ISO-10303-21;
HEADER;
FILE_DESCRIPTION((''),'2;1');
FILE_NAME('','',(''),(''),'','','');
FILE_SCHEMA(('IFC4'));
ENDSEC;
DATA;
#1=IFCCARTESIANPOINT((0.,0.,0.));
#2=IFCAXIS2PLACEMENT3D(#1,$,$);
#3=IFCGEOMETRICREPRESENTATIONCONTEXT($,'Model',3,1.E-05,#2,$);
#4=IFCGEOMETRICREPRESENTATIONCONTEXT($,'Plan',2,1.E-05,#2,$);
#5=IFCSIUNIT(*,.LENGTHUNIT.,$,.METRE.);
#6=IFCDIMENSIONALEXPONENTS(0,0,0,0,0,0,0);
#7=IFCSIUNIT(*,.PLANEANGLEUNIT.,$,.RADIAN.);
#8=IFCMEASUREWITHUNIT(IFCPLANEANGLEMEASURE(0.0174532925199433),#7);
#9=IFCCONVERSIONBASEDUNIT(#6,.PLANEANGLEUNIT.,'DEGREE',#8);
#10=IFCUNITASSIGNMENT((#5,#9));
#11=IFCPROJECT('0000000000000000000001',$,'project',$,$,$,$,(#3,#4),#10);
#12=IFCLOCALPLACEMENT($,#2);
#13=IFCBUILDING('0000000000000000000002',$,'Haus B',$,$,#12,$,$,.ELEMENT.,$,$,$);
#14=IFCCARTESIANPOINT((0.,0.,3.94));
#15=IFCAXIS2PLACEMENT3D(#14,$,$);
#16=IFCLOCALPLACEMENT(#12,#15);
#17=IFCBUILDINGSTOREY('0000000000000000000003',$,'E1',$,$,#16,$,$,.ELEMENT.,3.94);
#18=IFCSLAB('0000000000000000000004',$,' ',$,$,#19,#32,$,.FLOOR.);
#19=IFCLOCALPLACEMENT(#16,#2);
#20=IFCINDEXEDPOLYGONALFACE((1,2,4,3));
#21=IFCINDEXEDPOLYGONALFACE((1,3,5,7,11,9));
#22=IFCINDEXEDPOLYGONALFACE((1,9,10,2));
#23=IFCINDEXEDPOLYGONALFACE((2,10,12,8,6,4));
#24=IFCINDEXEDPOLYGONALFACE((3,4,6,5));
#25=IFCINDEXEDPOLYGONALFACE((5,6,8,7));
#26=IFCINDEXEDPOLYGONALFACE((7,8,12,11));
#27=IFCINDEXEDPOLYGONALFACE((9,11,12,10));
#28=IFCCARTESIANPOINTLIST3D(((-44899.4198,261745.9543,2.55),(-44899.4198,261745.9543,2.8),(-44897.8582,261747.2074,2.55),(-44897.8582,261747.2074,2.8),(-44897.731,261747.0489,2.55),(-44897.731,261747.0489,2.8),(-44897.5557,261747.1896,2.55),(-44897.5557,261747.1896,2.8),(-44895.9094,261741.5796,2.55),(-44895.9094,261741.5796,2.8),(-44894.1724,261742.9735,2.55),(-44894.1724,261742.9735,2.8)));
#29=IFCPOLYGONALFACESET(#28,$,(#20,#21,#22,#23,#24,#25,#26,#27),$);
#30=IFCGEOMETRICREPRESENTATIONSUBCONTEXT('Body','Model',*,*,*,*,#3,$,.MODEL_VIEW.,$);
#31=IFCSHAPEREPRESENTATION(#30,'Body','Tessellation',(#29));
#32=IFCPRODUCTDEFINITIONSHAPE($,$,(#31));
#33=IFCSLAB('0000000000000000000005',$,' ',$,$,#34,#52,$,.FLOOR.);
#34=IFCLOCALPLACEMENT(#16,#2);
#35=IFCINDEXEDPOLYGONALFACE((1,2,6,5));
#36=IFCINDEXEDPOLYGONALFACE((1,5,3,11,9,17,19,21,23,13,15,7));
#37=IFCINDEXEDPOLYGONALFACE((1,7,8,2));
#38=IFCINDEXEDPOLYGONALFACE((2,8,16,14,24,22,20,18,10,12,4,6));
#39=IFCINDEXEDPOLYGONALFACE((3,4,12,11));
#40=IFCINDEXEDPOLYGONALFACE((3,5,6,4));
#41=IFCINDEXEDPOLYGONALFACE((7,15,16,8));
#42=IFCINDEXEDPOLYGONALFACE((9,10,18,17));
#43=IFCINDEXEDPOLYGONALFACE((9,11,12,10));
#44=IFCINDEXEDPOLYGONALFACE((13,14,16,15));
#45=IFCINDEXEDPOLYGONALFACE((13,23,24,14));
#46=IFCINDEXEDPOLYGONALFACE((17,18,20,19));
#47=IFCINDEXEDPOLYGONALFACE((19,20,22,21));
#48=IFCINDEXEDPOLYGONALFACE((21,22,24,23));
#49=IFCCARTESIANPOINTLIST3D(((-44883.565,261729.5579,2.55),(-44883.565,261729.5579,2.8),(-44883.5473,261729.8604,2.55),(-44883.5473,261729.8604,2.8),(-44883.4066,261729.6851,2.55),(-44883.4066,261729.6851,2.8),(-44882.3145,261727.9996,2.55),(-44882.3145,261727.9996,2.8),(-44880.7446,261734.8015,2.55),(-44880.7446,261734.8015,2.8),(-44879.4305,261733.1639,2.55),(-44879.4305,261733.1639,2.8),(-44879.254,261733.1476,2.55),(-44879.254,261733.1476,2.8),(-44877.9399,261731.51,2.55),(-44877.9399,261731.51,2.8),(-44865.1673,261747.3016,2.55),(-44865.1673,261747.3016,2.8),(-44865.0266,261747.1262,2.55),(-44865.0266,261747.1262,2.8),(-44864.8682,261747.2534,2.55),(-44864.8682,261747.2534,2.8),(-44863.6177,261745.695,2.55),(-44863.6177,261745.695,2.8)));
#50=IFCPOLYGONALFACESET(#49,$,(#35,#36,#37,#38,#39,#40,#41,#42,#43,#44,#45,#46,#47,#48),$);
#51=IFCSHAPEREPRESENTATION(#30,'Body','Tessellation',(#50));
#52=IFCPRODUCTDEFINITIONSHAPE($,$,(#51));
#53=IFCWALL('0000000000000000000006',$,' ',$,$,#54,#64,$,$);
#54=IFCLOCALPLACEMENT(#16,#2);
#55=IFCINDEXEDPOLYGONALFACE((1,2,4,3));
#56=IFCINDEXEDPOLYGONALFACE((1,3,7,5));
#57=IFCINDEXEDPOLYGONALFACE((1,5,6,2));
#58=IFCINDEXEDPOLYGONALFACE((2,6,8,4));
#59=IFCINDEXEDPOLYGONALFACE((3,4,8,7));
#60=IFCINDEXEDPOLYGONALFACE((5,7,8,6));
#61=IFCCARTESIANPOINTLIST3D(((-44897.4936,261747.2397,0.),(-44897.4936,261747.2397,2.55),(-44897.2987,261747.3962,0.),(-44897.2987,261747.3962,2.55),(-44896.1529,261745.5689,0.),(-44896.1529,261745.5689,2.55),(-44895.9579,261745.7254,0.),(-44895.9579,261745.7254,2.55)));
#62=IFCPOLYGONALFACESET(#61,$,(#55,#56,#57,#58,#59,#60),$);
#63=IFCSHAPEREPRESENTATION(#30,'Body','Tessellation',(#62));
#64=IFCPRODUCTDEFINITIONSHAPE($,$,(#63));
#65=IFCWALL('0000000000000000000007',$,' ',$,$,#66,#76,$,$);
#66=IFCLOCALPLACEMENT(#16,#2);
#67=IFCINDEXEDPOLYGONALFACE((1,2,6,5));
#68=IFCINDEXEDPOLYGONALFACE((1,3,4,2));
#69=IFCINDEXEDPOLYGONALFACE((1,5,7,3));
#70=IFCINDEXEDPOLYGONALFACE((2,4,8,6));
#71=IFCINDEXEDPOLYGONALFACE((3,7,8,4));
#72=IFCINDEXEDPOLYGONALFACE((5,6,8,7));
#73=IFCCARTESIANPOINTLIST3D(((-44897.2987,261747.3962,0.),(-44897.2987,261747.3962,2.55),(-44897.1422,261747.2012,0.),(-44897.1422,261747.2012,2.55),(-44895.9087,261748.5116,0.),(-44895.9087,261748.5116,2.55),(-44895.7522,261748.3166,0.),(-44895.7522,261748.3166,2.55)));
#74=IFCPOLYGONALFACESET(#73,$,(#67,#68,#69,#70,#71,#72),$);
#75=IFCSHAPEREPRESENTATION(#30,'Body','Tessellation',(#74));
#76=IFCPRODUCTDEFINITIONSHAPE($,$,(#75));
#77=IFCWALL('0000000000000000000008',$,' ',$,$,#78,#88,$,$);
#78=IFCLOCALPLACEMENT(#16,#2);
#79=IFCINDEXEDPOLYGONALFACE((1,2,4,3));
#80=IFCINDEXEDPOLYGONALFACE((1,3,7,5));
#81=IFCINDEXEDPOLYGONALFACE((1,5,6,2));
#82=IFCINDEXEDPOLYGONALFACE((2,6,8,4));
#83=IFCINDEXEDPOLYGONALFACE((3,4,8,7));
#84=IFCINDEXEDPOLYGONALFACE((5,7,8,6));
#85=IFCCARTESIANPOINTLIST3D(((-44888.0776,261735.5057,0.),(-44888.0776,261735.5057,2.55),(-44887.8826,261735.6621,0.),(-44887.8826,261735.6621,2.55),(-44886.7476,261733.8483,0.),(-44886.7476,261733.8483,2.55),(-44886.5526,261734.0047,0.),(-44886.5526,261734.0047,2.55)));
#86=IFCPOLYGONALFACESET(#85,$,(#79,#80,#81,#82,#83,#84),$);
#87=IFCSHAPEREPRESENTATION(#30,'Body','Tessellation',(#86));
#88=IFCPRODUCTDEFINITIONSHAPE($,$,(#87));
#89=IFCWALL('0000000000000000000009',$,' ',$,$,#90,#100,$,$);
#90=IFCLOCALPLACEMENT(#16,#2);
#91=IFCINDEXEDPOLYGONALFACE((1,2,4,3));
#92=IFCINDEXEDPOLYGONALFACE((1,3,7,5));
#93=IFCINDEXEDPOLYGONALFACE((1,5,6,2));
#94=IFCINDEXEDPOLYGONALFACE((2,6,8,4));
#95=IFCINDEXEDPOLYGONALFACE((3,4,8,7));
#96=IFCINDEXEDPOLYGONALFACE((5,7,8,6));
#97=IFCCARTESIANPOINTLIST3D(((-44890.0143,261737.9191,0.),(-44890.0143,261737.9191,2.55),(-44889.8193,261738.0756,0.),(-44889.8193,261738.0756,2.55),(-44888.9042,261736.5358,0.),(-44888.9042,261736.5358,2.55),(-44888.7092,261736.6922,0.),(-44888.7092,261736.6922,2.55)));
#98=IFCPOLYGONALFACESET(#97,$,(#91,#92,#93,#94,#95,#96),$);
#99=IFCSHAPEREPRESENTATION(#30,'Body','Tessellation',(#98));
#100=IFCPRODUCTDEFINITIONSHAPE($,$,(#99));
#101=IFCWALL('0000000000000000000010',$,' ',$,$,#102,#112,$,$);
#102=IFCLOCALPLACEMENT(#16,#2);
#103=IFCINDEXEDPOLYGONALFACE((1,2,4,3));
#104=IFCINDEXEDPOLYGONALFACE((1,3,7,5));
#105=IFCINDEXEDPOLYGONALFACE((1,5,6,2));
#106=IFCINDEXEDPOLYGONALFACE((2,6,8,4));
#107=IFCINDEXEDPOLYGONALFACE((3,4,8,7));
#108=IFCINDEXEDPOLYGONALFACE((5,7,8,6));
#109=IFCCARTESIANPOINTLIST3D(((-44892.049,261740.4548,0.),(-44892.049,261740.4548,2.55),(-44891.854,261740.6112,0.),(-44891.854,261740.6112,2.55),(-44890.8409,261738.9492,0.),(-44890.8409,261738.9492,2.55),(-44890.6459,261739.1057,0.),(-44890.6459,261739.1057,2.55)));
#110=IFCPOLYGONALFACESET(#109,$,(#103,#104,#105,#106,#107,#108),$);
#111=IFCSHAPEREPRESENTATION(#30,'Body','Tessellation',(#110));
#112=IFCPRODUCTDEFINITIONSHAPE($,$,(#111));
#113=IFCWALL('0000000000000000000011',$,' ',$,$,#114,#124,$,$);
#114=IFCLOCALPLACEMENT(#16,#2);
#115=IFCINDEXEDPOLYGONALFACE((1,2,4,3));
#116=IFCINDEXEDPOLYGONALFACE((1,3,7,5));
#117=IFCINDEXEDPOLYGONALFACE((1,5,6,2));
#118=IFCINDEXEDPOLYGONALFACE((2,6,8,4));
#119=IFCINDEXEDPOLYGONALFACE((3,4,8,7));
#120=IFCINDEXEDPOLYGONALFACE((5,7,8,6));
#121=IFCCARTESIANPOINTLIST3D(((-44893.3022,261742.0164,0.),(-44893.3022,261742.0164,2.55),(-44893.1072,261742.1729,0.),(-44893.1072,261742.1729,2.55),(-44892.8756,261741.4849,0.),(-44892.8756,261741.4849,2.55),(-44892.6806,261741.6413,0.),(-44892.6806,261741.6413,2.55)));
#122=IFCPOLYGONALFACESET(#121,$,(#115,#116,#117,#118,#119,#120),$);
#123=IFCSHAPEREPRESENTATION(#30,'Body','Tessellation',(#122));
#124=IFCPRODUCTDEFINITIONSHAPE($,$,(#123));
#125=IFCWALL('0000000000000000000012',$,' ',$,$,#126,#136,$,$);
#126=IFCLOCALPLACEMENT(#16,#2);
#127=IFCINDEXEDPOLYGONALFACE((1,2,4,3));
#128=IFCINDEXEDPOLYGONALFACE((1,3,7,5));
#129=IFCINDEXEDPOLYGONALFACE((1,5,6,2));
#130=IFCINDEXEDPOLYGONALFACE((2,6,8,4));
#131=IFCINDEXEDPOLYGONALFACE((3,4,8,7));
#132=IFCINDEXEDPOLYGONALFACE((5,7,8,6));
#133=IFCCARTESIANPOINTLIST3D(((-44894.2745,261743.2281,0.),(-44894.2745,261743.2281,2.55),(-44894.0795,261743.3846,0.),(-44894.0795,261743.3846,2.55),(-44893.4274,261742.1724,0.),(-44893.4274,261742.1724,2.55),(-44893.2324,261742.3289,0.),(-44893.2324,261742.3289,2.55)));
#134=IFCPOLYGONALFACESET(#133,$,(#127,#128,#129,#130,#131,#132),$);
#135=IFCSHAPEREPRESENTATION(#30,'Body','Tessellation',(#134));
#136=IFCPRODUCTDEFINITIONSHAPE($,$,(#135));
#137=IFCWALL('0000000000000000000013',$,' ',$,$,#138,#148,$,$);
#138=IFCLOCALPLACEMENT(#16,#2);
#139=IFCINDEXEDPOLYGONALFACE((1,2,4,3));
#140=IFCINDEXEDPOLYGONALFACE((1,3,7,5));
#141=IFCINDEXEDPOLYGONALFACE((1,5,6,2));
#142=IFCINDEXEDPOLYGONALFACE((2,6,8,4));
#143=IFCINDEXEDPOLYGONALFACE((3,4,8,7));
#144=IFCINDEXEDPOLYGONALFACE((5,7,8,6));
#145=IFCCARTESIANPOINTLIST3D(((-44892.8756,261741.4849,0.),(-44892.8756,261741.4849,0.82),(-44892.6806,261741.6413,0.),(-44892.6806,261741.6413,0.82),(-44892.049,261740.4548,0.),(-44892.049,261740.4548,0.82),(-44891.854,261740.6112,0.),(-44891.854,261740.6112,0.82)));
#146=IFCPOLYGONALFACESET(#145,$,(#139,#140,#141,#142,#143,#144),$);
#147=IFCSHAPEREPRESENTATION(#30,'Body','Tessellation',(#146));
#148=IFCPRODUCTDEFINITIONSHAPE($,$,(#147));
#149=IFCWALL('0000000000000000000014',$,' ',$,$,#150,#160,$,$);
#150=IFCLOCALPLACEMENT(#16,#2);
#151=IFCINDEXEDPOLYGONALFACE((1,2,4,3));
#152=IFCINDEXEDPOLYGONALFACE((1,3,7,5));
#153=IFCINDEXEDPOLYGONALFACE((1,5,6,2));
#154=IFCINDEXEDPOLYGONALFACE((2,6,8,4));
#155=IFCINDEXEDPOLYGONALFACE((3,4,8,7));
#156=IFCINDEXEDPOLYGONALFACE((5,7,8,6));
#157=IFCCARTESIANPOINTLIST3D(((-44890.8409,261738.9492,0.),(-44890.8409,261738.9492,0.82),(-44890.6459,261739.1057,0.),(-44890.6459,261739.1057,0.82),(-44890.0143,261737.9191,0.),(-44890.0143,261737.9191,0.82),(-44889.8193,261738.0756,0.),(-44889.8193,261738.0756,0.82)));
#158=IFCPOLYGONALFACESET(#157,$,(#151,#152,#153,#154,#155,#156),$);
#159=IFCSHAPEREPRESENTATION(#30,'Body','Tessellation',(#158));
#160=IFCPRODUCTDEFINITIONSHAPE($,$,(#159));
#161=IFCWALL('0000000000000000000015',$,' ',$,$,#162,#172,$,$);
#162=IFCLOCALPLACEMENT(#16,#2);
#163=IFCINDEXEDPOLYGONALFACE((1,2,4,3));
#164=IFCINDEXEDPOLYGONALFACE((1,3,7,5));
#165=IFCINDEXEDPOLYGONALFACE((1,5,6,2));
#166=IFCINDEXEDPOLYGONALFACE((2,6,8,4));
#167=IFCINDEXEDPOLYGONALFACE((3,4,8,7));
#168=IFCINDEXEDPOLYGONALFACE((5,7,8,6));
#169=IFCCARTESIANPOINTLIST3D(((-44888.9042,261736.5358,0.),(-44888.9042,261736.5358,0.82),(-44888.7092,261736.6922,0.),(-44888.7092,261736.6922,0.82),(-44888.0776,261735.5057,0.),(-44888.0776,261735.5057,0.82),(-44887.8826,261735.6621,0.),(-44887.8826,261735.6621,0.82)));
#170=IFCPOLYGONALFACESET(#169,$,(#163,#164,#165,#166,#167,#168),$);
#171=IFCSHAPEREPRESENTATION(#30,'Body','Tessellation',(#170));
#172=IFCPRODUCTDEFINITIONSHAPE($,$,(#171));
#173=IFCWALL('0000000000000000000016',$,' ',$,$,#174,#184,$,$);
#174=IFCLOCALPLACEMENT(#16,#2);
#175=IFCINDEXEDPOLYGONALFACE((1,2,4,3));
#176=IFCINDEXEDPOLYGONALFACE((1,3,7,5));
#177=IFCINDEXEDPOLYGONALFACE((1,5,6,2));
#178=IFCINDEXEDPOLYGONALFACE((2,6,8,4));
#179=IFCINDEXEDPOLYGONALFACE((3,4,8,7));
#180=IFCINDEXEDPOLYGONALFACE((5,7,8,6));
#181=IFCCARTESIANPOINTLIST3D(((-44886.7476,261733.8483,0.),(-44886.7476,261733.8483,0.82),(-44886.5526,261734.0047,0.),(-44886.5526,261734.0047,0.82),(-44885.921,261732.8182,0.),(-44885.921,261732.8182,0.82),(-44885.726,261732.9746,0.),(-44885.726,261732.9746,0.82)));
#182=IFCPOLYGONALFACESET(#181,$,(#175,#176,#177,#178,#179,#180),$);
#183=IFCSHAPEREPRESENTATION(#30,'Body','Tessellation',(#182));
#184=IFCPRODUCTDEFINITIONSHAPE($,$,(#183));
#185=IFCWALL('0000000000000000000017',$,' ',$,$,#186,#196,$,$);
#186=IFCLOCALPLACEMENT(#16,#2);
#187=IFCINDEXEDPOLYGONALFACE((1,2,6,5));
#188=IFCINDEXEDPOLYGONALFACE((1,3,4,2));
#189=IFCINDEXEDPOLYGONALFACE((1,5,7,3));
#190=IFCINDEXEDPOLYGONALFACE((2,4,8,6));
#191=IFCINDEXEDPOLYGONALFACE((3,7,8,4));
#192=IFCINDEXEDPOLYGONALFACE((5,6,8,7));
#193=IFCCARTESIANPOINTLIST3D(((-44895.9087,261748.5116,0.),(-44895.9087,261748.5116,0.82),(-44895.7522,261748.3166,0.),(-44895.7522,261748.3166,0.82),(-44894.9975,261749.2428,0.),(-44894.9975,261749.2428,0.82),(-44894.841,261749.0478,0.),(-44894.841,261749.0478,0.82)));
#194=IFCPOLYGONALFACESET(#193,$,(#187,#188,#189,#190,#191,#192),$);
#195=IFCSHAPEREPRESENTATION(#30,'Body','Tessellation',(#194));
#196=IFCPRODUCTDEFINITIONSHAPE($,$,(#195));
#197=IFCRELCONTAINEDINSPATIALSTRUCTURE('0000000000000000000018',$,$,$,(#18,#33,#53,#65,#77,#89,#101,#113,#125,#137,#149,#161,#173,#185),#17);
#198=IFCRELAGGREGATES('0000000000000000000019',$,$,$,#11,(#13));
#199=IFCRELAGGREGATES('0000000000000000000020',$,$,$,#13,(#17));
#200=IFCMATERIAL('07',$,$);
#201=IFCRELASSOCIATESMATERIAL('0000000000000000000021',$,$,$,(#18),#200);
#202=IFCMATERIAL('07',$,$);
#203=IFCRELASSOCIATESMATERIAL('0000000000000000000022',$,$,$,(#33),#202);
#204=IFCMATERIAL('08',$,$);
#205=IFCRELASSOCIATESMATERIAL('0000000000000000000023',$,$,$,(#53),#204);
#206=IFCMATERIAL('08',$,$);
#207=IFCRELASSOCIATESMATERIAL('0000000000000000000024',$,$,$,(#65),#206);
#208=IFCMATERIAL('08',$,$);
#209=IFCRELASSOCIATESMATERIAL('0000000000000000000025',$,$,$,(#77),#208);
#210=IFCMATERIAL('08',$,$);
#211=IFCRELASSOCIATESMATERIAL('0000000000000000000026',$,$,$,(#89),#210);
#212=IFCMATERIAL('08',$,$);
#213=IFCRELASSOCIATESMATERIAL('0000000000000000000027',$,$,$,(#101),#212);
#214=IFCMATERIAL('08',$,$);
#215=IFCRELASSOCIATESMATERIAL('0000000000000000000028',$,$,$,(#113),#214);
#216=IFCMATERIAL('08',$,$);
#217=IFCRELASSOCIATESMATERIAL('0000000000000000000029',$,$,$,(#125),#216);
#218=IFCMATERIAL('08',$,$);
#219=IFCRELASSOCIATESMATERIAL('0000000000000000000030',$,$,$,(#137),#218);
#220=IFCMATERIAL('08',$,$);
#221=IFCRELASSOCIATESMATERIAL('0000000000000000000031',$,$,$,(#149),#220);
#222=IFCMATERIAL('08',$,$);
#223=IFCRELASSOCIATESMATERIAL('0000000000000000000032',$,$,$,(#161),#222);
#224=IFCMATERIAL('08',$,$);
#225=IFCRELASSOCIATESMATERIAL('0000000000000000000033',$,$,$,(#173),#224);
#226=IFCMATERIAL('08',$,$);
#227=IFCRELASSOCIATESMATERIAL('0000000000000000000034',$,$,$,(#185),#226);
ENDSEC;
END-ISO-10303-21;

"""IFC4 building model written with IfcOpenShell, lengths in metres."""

from ifc_helpers import new_model, entity, si_unit, converted_unit, frame, frame_2d, origin, origin_with_axes, place, context, subcontext, project, spatial, polyline, rectangle, outline, extrude, material, element, save


model = new_model("IFC4")

# Units and contexts
model_context = context("Model", 3, precision=1e-05, world=origin())
plan_context = context("Plan", 2, precision=1e-05, world=origin())
body_context = subcontext(model_context, "Body", "Model", "MODEL_VIEW")
ifc_project = project(units=[si_unit("LENGTHUNIT", "METRE"), converted_unit("PLANEANGLEUNIT", "DEGREE", entity("IfcPlaneAngleMeasure", 0.0174532925199433), si_unit("PLANEANGLEUNIT", "RADIAN"), dimensions=[0, 0, 0, 0, 0, 0, 0])], contexts=[model_context, plan_context])

# Building, storey
building_placement = place(None, origin())
building = spatial("IfcBuilding", under=ifc_project, at=building_placement, Name="Haus B", CompositionType="ELEMENT")
storey_placement = place(building_placement, frame((0.0, 0.0, 3.94)))
storey = spatial("IfcBuildingStorey", under=building, at=storey_placement, Name="E1", CompositionType="ELEMENT", Elevation=3.94)

# Slabs
ifc_material_1 = material(Name="07")
slab_1_placement = place(storey_placement, frame((-44899.4198, 261741.5796, 2.55)))
element("IfcSlab", 1, at=slab_1_placement, inside=storey, material=ifc_material_1, Name=" ", PredefinedType="FLOOR", context=body_context, shape_type="SweptSolid", body=[
    extrude(outline(polyline([(1.8641, 5.61), (1.6888, 5.4693), (1.5617, 5.6278), (0.0, 4.3746), (3.5104, 0.0), (5.2474, 1.3938), (1.8641, 5.61)])), origin_with_axes(), (0.0, 0.0, 1.0), 0.25),
])
ifc_material_2 = material(Name="07")
slab_2_placement = place(storey_placement, frame((-44883.565, 261727.9996, 2.55)))
element("IfcSlab", 2, at=slab_2_placement, inside=storey, material=ifc_material_2, Name=" ", PredefinedType="FLOOR", context=body_context, shape_type="SweptSolid", body=[
    extrude(outline(polyline([(18.3977, 19.302), (2.8205, 6.8019), (4.1345, 5.1643), (0.0178, 1.8608), (0.1585, 1.6855), (0.0, 1.5584), (1.2505, 0.0), (5.6251, 3.5104), (4.311, 5.148), (19.9474, 17.6955), (18.6969, 19.2538), (18.5384, 19.1266), (18.3977, 19.302)])), origin_with_axes(), (0.0, 0.0, 1.0), 0.25),
])

# Walls
ifc_material_3 = material(Name="08")
wall_1_placement = place(storey_placement, frame((-44895.9579, 261745.7254, 0.0), z_axis=(0.0, 0.0, 1.0), x_axis=(-0.625861, 0.779935, 0.0)))
element("IfcWall", 3, at=wall_1_placement, inside=storey, material=ifc_material_3, Name=" ", context=body_context, shape_type="SweptSolid", body=[
    extrude(rectangle(XDim=2.1422, YDim=0.25, at=frame_2d((1.0711, 0.125), x_axis=(1.0, 0.0))), origin_with_axes(), (0.0, 0.0, 1.0), 2.55),
])
ifc_material_4 = material(Name="08")
wall_2_placement = place(storey_placement, frame((-44897.1422, 261747.2012, 0.0), z_axis=(0.0, 0.0, 1.0), x_axis=(0.779935, 0.625861, 0.0)))
element("IfcWall", 4, at=wall_2_placement, inside=storey, material=ifc_material_4, Name=" ", context=body_context, shape_type="SweptSolid", body=[
    extrude(rectangle(XDim=1.7822, YDim=0.25, at=frame_2d((0.8911, 0.125), x_axis=(1.0, 0.0))), origin_with_axes(), (0.0, 0.0, 1.0), 2.55),
])
ifc_material_5 = material(Name="08")
wall_3_placement = place(storey_placement, frame((-44886.5526, 261734.0047, 0.0), z_axis=(0.0, 0.0, 1.0), x_axis=(-0.625861, 0.779935, 0.0)))
element("IfcWall", 5, at=wall_3_placement, inside=storey, material=ifc_material_5, Name=" ", context=body_context, shape_type="SweptSolid", body=[
    extrude(rectangle(XDim=2.1251, YDim=0.25, at=frame_2d((1.0625, 0.125), x_axis=(1.0, 0.0))), origin_with_axes(), (0.0, 0.0, 1.0), 2.55),
])
ifc_material_6 = material(Name="08")
wall_4_placement = place(storey_placement, frame((-44888.7092, 261736.6922, 0.0), z_axis=(0.0, 0.0, 1.0), x_axis=(-0.625861, 0.779935, 0.0)))
element("IfcWall", 6, at=wall_4_placement, inside=storey, material=ifc_material_6, Name=" ", context=body_context, shape_type="SweptSolid", body=[
    extrude(rectangle(XDim=1.7737, YDim=0.25, at=frame_2d((0.8868, 0.125), x_axis=(1.0, 0.0))), origin_with_axes(), (0.0, 0.0, 1.0), 2.55),
])
ifc_material_7 = material(Name="08")
wall_5_placement = place(storey_placement, frame((-44890.6459, 261739.1057, 0.0), z_axis=(0.0, 0.0, 1.0), x_axis=(-0.625861, 0.779935, 0.0)))
element("IfcWall", 7, at=wall_5_placement, inside=storey, material=ifc_material_7, Name=" ", context=body_context, shape_type="SweptSolid", body=[
    extrude(rectangle(XDim=1.9303, YDim=0.25, at=frame_2d((0.9652, 0.125), x_axis=(1.0, 0.0))), origin_with_axes(), (0.0, 0.0, 1.0), 2.55),
])
ifc_material_8 = material(Name="08")
wall_6_placement = place(storey_placement, frame((-44892.6806, 261741.6413, 0.0), z_axis=(0.0, 0.0, 1.0), x_axis=(-0.625861, 0.779935, 0.0)))
element("IfcWall", 8, at=wall_6_placement, inside=storey, material=ifc_material_8, Name=" ", context=body_context, shape_type="SweptSolid", body=[
    extrude(rectangle(XDim=0.6815, YDim=0.25, at=frame_2d((0.3408, 0.125), x_axis=(1.0, 0.0))), origin_with_axes(), (0.0, 0.0, 1.0), 2.55),
])
ifc_material_9 = material(Name="08")
wall_7_placement = place(storey_placement, frame((-44893.2324, 261742.3289, 0.0), z_axis=(0.0, 0.0, 1.0), x_axis=(-0.625861, 0.779935, 0.0)))
element("IfcWall", 9, at=wall_7_placement, inside=storey, material=ifc_material_9, Name=" ", context=body_context, shape_type="SweptSolid", body=[
    extrude(rectangle(XDim=1.3536, YDim=0.25, at=frame_2d((0.6768, 0.125), x_axis=(1.0, 0.0))), origin_with_axes(), (0.0, 0.0, 1.0), 2.55),
])
ifc_material_10 = material(Name="08")
wall_8_placement = place(storey_placement, frame((-44891.854, 261740.6112, 0.0), z_axis=(0.0, 0.0, 1.0), x_axis=(-0.625861, 0.779935, 0.0)))
element("IfcWall", 10, at=wall_8_placement, inside=storey, material=ifc_material_10, Name=" ", context=body_context, shape_type="SweptSolid", body=[
    extrude(rectangle(XDim=1.3207, YDim=0.25, at=frame_2d((0.6604, 0.125), x_axis=(1.0, 0.0))), origin_with_axes(), (0.0, 0.0, 1.0), 0.82),
])
ifc_material_11 = material(Name="08")
wall_9_placement = place(storey_placement, frame((-44889.8193, 261738.0756, 0.0), z_axis=(0.0, 0.0, 1.0), x_axis=(-0.625861, 0.779935, 0.0)))
element("IfcWall", 11, at=wall_9_placement, inside=storey, material=ifc_material_11, Name=" ", context=body_context, shape_type="SweptSolid", body=[
    extrude(rectangle(XDim=1.3207, YDim=0.25, at=frame_2d((0.6604, 0.125), x_axis=(1.0, 0.0))), origin_with_axes(), (0.0, 0.0, 1.0), 0.82),
])
ifc_material_12 = material(Name="08")
wall_10_placement = place(storey_placement, frame((-44887.8826, 261735.6621, 0.0), z_axis=(0.0, 0.0, 1.0), x_axis=(-0.625861, 0.779935, 0.0)))
element("IfcWall", 12, at=wall_10_placement, inside=storey, material=ifc_material_12, Name=" ", context=body_context, shape_type="SweptSolid", body=[
    extrude(rectangle(XDim=1.3207, YDim=0.25, at=frame_2d((0.6604, 0.125), x_axis=(1.0, 0.0))), origin_with_axes(), (0.0, 0.0, 1.0), 0.82),
])
ifc_material_13 = material(Name="08")
wall_11_placement = place(storey_placement, frame((-44885.726, 261732.9746, 0.0), z_axis=(0.0, 0.0, 1.0), x_axis=(-0.625861, 0.779935, 0.0)))
element("IfcWall", 13, at=wall_11_placement, inside=storey, material=ifc_material_13, Name=" ", context=body_context, shape_type="SweptSolid", body=[
    extrude(rectangle(XDim=1.3207, YDim=0.25, at=frame_2d((0.6604, 0.125), x_axis=(1.0, 0.0))), origin_with_axes(), (0.0, 0.0, 1.0), 0.82),
])
ifc_material_14 = material(Name="08")
wall_12_placement = place(storey_placement, frame((-44895.7522, 261748.3166, 0.0), z_axis=(0.0, 0.0, 1.0), x_axis=(0.779935, 0.625861, 0.0)))
element("IfcWall", 14, at=wall_12_placement, inside=storey, material=ifc_material_14, Name=" ", context=body_context, shape_type="SweptSolid", body=[
    extrude(rectangle(XDim=1.1684, YDim=0.25, at=frame_2d((0.5842, 0.125), x_axis=(1.0, 0.0))), origin_with_axes(), (0.0, 0.0, 1.0), 0.82),
])

save(model, "model.ifc")
